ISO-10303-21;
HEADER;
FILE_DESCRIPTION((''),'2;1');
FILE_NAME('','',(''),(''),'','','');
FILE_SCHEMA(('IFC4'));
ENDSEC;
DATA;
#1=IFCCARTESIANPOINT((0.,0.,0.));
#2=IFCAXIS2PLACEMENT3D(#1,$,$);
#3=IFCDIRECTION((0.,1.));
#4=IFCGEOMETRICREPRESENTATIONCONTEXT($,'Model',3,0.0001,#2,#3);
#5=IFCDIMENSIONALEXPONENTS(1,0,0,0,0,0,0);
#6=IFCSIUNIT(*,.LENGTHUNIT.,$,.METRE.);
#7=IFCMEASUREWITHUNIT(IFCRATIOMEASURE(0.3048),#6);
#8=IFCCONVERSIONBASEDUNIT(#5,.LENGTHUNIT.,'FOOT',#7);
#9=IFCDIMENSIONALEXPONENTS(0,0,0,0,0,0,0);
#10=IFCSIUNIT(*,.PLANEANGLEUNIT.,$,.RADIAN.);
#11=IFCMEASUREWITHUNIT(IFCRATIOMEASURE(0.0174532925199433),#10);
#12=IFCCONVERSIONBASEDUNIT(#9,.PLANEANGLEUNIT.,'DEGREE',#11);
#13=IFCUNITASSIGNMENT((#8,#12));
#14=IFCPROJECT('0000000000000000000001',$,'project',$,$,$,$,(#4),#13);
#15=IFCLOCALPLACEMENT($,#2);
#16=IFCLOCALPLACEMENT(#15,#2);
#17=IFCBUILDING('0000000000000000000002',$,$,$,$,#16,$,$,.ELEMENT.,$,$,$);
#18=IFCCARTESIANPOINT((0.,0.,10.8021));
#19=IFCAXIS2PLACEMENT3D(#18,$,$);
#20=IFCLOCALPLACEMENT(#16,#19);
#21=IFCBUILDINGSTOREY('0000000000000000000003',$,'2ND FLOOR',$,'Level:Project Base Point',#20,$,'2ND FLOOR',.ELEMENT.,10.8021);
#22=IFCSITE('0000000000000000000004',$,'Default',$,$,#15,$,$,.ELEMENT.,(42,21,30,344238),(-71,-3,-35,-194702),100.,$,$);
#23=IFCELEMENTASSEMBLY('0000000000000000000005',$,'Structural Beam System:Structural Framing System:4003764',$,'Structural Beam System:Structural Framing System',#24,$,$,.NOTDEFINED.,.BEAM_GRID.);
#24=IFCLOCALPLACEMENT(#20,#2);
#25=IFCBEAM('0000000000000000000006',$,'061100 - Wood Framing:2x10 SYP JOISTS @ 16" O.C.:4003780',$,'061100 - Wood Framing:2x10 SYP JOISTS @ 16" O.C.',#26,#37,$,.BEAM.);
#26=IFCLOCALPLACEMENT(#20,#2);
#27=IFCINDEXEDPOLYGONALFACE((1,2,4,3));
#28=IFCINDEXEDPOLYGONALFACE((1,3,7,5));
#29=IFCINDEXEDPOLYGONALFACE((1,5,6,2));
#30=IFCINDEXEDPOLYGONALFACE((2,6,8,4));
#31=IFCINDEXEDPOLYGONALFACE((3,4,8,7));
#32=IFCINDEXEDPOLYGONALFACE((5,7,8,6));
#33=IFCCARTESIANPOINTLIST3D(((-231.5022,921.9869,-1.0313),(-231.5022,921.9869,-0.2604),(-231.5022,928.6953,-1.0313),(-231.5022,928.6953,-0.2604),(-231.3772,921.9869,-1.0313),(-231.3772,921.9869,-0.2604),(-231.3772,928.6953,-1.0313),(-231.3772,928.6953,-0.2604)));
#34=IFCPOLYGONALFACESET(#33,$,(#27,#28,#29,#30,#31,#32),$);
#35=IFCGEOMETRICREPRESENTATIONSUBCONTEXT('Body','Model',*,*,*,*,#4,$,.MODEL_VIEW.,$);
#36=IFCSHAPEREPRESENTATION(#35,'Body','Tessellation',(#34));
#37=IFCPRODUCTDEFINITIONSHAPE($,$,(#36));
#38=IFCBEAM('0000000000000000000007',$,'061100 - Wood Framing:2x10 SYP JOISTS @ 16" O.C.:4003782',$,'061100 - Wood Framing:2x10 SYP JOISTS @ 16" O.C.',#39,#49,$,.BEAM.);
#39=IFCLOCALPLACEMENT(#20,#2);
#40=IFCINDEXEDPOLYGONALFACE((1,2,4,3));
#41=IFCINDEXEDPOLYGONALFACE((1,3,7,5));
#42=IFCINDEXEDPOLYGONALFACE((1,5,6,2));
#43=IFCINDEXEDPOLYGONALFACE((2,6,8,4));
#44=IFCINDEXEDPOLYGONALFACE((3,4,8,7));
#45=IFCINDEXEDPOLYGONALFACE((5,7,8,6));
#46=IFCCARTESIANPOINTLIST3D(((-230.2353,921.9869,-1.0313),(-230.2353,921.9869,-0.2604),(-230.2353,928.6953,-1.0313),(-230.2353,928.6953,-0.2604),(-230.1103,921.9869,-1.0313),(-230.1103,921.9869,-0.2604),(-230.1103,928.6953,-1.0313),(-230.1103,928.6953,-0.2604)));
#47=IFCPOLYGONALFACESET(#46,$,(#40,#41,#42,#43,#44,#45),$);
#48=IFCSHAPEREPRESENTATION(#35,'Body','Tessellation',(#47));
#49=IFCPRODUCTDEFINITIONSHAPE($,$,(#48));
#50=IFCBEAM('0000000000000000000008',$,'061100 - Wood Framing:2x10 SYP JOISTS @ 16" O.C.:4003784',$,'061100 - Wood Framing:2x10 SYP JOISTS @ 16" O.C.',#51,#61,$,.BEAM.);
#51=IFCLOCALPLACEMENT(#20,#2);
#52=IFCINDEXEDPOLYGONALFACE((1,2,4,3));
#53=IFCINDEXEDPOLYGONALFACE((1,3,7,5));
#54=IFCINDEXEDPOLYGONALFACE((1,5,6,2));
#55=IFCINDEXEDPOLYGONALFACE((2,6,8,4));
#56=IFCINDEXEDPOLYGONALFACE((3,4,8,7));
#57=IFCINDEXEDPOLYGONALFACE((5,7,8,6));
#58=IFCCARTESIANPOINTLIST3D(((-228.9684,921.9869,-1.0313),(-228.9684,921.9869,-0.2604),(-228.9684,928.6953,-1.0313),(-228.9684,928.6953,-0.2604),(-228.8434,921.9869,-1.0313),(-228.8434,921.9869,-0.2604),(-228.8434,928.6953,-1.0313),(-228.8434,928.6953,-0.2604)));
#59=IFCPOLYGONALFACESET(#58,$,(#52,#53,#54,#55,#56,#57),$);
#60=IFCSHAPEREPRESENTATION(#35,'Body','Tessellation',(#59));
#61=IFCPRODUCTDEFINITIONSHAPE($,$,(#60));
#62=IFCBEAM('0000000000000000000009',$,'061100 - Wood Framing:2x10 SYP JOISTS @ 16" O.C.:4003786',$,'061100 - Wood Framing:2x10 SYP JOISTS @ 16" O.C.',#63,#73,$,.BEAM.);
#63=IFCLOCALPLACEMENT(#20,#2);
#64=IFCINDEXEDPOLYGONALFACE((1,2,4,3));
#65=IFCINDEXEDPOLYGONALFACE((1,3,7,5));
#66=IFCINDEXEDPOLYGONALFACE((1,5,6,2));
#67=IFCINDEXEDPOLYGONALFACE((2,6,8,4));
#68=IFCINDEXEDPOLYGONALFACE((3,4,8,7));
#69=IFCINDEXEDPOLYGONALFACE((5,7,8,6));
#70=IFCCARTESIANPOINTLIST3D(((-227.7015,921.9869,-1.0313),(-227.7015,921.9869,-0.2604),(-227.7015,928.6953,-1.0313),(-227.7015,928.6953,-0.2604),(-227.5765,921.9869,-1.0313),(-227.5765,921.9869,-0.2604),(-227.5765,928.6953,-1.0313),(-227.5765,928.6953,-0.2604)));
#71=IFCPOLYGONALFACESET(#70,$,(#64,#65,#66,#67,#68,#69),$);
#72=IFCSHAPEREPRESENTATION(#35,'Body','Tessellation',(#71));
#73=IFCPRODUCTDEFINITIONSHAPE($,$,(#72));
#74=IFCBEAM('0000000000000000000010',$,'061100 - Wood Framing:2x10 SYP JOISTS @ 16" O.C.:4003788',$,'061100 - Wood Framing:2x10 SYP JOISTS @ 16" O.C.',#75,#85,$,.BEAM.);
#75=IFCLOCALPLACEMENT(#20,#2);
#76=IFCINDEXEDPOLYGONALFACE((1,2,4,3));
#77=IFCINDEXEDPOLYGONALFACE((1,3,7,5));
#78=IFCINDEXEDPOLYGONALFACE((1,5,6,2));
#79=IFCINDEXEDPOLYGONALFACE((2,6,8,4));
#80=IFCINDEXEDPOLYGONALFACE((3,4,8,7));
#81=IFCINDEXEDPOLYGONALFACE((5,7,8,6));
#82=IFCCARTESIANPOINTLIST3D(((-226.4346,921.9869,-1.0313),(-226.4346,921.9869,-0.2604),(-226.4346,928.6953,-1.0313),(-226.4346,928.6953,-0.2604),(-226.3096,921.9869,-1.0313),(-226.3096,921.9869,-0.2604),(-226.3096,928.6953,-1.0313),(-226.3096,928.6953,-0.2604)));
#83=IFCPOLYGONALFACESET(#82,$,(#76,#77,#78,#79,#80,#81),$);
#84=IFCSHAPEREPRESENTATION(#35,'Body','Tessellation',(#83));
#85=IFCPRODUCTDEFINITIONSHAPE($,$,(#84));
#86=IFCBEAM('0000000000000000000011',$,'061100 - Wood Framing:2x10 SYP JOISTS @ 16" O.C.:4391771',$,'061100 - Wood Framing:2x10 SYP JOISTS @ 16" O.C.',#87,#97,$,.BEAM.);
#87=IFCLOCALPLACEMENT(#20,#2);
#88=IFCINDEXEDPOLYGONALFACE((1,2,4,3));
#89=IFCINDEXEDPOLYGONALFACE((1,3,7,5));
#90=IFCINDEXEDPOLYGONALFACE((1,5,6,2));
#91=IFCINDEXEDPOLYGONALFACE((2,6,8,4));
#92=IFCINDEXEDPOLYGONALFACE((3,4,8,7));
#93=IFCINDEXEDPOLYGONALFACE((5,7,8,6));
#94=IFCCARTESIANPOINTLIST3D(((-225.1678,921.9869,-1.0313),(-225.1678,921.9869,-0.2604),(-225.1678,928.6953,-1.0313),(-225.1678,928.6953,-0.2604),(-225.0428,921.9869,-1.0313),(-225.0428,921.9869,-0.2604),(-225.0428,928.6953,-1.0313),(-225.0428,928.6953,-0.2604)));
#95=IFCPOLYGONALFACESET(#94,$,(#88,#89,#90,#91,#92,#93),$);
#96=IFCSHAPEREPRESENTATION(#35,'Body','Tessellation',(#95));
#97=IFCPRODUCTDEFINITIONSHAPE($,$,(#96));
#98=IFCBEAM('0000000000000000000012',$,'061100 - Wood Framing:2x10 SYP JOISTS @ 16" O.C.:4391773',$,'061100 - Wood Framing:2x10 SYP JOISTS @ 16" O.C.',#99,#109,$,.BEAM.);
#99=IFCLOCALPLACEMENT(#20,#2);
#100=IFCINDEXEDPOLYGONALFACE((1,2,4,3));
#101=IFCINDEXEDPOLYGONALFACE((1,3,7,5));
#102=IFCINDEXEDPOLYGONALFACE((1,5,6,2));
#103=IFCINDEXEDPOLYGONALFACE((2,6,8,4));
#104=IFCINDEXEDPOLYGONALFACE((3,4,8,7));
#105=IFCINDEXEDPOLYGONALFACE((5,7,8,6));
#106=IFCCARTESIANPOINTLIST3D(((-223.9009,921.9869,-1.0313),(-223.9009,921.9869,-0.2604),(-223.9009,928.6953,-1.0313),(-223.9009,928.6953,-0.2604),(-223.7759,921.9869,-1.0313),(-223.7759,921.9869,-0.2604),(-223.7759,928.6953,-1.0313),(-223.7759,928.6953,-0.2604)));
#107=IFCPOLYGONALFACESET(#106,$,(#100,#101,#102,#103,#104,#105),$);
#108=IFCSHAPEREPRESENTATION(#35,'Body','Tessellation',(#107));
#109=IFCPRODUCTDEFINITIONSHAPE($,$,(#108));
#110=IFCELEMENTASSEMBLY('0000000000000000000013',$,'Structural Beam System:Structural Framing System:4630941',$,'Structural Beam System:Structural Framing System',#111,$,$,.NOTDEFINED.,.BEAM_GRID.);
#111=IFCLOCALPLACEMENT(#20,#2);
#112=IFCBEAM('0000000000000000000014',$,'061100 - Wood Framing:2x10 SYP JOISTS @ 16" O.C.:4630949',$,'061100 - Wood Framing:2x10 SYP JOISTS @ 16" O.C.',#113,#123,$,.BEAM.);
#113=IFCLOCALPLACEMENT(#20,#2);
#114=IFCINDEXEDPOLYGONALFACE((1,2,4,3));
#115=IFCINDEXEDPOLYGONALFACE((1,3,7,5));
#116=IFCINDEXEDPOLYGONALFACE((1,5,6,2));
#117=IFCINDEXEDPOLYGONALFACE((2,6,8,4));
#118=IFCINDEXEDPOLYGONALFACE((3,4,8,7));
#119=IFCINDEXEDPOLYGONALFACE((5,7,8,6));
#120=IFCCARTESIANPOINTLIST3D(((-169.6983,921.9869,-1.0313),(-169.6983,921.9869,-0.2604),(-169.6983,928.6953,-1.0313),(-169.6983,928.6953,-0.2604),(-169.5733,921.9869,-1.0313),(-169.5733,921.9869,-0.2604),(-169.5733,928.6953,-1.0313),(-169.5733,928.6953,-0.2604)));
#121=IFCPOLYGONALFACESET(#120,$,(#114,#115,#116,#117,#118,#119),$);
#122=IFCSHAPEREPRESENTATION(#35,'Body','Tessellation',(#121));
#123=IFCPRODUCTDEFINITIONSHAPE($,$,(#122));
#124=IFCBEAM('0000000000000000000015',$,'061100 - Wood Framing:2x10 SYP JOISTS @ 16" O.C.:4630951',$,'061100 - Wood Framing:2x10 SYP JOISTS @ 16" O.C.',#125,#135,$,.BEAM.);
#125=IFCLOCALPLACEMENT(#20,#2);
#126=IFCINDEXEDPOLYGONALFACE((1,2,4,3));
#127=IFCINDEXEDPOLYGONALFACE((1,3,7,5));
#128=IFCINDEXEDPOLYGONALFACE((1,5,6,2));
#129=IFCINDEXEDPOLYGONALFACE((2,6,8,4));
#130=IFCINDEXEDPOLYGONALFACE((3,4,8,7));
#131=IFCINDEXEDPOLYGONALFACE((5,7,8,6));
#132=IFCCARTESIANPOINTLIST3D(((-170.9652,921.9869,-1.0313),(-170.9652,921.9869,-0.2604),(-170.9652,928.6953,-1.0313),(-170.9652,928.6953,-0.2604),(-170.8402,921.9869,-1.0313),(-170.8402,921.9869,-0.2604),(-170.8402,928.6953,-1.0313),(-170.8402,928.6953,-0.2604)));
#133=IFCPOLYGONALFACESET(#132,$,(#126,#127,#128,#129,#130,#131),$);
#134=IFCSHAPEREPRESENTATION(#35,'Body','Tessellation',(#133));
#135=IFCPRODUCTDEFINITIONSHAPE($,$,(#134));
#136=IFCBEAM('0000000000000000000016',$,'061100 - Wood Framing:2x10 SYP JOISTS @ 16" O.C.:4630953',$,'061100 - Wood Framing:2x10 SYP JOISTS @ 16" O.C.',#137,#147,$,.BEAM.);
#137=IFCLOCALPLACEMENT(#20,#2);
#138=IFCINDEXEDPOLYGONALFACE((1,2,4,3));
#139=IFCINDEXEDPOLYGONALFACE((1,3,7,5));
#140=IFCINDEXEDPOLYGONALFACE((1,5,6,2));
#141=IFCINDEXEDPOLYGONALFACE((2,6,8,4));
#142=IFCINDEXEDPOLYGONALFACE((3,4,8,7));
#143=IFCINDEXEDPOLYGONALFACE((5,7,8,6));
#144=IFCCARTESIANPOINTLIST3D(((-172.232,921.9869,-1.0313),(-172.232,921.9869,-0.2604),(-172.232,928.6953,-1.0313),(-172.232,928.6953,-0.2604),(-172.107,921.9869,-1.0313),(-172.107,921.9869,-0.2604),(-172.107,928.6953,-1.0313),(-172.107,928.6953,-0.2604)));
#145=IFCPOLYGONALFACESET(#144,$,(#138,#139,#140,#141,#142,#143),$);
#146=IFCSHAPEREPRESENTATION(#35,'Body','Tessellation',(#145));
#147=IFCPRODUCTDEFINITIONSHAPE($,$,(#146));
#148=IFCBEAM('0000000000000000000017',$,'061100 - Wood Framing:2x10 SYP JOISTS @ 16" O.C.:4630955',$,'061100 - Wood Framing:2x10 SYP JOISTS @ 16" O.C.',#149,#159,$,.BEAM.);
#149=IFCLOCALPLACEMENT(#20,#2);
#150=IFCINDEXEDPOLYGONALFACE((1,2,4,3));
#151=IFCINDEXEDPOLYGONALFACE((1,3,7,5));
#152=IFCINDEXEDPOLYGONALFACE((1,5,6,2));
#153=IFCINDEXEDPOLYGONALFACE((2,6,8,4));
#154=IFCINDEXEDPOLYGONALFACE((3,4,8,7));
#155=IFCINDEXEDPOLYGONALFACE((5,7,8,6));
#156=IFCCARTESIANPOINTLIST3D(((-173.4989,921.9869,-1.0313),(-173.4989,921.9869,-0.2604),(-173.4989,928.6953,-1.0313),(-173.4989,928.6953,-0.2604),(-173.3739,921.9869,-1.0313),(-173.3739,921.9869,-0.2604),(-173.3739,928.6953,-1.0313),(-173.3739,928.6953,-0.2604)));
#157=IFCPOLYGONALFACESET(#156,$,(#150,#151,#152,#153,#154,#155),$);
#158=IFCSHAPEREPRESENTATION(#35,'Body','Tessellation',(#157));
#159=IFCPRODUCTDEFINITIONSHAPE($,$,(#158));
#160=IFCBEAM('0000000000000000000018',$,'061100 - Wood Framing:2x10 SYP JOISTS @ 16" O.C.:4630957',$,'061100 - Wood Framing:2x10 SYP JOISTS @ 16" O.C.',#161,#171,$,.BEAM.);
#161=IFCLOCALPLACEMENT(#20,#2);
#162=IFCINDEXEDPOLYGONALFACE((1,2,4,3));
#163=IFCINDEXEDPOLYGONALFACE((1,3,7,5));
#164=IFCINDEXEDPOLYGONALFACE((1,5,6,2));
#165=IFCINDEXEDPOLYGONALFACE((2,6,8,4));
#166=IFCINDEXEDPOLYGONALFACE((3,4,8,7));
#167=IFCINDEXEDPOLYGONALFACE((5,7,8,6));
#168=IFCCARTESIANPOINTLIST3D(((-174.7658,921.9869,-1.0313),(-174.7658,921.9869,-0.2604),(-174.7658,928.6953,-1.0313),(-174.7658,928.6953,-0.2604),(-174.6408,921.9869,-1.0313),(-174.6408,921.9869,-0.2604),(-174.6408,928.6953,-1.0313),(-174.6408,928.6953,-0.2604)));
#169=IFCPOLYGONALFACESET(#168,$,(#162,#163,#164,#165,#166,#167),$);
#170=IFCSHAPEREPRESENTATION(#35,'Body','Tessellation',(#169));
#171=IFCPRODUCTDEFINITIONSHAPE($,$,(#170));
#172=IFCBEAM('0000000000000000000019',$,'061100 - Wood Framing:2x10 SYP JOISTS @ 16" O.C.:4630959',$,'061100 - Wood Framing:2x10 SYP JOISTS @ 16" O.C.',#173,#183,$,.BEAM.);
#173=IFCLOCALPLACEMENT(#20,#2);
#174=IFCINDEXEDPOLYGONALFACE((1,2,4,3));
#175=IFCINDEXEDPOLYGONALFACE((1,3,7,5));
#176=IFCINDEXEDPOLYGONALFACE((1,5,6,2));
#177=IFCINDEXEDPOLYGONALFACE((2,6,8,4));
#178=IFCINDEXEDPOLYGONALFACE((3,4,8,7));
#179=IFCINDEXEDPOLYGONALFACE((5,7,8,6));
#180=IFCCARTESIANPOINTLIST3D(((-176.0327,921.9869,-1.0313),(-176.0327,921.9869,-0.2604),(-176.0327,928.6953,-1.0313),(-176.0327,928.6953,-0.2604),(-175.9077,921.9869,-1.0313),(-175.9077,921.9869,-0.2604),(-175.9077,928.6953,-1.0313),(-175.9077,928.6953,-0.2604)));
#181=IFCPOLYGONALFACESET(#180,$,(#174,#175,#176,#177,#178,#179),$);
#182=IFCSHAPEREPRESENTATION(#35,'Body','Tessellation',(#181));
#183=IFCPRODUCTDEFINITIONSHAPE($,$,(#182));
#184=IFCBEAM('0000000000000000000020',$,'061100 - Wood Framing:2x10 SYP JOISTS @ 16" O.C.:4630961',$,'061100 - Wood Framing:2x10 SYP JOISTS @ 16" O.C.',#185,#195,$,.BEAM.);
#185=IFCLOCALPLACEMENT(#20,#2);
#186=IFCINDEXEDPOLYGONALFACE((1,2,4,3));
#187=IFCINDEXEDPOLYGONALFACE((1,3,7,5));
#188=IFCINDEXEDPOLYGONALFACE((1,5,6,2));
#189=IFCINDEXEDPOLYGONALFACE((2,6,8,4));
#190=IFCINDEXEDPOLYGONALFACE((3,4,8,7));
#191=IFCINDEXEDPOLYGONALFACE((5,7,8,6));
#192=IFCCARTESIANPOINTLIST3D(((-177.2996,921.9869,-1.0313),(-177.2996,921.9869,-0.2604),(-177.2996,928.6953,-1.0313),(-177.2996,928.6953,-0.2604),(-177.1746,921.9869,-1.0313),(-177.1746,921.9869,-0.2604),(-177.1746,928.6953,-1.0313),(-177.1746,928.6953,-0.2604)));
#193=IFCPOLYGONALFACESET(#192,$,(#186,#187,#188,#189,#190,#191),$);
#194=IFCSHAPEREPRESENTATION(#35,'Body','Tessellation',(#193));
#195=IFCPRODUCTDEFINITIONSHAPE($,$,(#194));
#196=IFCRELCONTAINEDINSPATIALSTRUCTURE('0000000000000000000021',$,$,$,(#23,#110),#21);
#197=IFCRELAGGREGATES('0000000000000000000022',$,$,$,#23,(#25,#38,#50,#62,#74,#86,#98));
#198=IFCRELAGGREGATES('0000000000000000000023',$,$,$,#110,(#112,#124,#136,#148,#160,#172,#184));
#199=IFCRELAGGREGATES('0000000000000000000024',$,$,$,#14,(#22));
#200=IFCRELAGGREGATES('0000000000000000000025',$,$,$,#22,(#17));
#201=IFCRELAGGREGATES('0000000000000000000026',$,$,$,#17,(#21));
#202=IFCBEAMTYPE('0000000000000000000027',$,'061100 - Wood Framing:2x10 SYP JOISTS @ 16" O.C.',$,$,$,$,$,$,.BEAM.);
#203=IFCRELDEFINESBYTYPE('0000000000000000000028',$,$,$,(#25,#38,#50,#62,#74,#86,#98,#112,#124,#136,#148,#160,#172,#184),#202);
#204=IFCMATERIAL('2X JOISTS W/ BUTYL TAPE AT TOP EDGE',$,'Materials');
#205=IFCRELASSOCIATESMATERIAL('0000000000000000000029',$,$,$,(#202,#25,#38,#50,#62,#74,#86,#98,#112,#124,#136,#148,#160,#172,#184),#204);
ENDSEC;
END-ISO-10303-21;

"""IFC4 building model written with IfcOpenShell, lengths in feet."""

from ifc_helpers import new_model, entity, si_unit, converted_unit, direction, frame, frame_2d, origin, place, context, subcontext, project, spatial, rectangle, extrude, source, transform, mapped, material, material_profile, profile_set, profile_usage, type_object, type_shapes, element, aggregate, save


model = new_model("IFC4")

# Units and contexts
model_context = context("Model", 3, precision=0.0001, world=origin(), true_north=direction((0.0, 1.0)))
body_context = subcontext(model_context, "Body", "Model", "MODEL_VIEW")
ifc_project = project(units=[converted_unit("LENGTHUNIT", "FOOT", entity("IfcRatioMeasure", 0.3048), si_unit("LENGTHUNIT", "METRE"), dimensions=[1, 0, 0, 0, 0, 0, 0]), converted_unit("PLANEANGLEUNIT", "DEGREE", entity("IfcRatioMeasure", 0.0174532925199433), si_unit("PLANEANGLEUNIT", "RADIAN"), dimensions=[0, 0, 0, 0, 0, 0, 0])], contexts=[model_context])

# Site, building, storey
site_placement = place(None, origin())
site = spatial("IfcSite", under=ifc_project, at=site_placement, Name="Default", CompositionType="ELEMENT", RefLatitude=(42, 21, 30, 344238), RefLongitude=(-71, -3, -35, -194702), RefElevation=100.0)
building_placement = place(site_placement, origin())
building = spatial("IfcBuilding", under=site, at=building_placement, CompositionType="ELEMENT")
storey_placement = place(building_placement, frame((0.0, 0.0, 10.8021)))
storey = spatial("IfcBuildingStorey", under=building, at=storey_placement, Name="2ND FLOOR", ObjectType="Level:Project Base Point", LongName="2ND FLOOR", CompositionType="ELEMENT", Elevation=10.8021)

# Element assemblies, beams
assembly_1_placement = place(storey_placement, origin())
assembly_1 = element("IfcElementAssembly", 1, at=assembly_1_placement, inside=storey, Name="Structural Beam System:Structural Framing System:4003764", ObjectType="Structural Beam System:Structural Framing System", AssemblyPlace="NOTDEFINED", PredefinedType="BEAM_GRID")
ifc_material_1 = material(Name="2X JOISTS W/ BUTYL TAPE AT TOP EDGE", Category="Materials")
ifc_material_profile_1 = material_profile(ifc_material_1, rectangle(XDim=0.7708, YDim=0.125, at=frame_2d((0.0, 0.0), x_axis=(1.0, 0.0))), Name="2x10 SYP JOISTS @ 16\" O.C.")
ifc_profile_set_1 = profile_set([ifc_material_profile_1], Name="2x10 SYP JOISTS @ 16\" O.C.")
ifc_profile_usage_1 = profile_usage(ifc_profile_set_1, cardinal=8)
beam_type_1 = type_object("IfcBeamType", Name="061100 - Wood Framing:2x10 SYP JOISTS @ 16\" O.C.", PredefinedType="BEAM", material=ifc_profile_set_1)
shared_shape_1 = source(origin(), body_context, "Body", "SweptSolid", [
    extrude(rectangle(XDim=0.7708, YDim=0.125, at=frame_2d((0.0, 0.0), x_axis=(1.0, 0.0))), frame((-3.3542, 0.0, 0.0), z_axis=(1.0, 0.0, 0.0), x_axis=(0.0, 0.0, -1.0)), (0.0, 0.0, 1.0), 6.7083),
])
type_shapes(beam_type_1, [shared_shape_1])
beam_1_placement = place(assembly_1_placement, frame((-231.4397, 925.3411, -0.6458), z_axis=(0.0, 0.0, 1.0), x_axis=(0.0, 1.0, 0.0)))
beam_1 = element("IfcBeam", 2, at=beam_1_placement, type_object=beam_type_1, material=ifc_profile_usage_1, Name="061100 - Wood Framing:2x10 SYP JOISTS @ 16\" O.C.:4003780", ObjectType="061100 - Wood Framing:2x10 SYP JOISTS @ 16\" O.C.", PredefinedType="BEAM", context=body_context, shape_type="MappedRepresentation", body=[
    mapped(shared_shape_1, transform((0.0, 0.0, 0.0), scale=1.0)),
])
ifc_profile_usage_2 = profile_usage(ifc_profile_set_1, cardinal=8)
beam_2_placement = place(assembly_1_placement, frame((-230.1728, 925.3411, -0.6458), z_axis=(0.0, 0.0, 1.0), x_axis=(0.0, 1.0, 0.0)))
beam_2 = element("IfcBeam", 3, at=beam_2_placement, type_object=beam_type_1, material=ifc_profile_usage_2, Name="061100 - Wood Framing:2x10 SYP JOISTS @ 16\" O.C.:4003782", ObjectType="061100 - Wood Framing:2x10 SYP JOISTS @ 16\" O.C.", PredefinedType="BEAM", context=body_context, shape_type="MappedRepresentation", body=[
    mapped(shared_shape_1, transform((0.0, 0.0, 0.0), scale=1.0)),
])
ifc_profile_usage_3 = profile_usage(ifc_profile_set_1, cardinal=8)
beam_3_placement = place(assembly_1_placement, frame((-228.9059, 925.3411, -0.6458), z_axis=(0.0, 0.0, 1.0), x_axis=(0.0, 1.0, 0.0)))
beam_3 = element("IfcBeam", 4, at=beam_3_placement, type_object=beam_type_1, material=ifc_profile_usage_3, Name="061100 - Wood Framing:2x10 SYP JOISTS @ 16\" O.C.:4003784", ObjectType="061100 - Wood Framing:2x10 SYP JOISTS @ 16\" O.C.", PredefinedType="BEAM", context=body_context, shape_type="MappedRepresentation", body=[
    mapped(shared_shape_1, transform((0.0, 0.0, 0.0), scale=1.0)),
])
ifc_profile_usage_4 = profile_usage(ifc_profile_set_1, cardinal=8)
beam_4_placement = place(assembly_1_placement, frame((-227.639, 925.3411, -0.6458), z_axis=(0.0, 0.0, 1.0), x_axis=(0.0, 1.0, 0.0)))
beam_4 = element("IfcBeam", 5, at=beam_4_placement, type_object=beam_type_1, material=ifc_profile_usage_4, Name="061100 - Wood Framing:2x10 SYP JOISTS @ 16\" O.C.:4003786", ObjectType="061100 - Wood Framing:2x10 SYP JOISTS @ 16\" O.C.", PredefinedType="BEAM", context=body_context, shape_type="MappedRepresentation", body=[
    mapped(shared_shape_1, transform((0.0, 0.0, 0.0), scale=1.0)),
])
ifc_profile_usage_5 = profile_usage(ifc_profile_set_1, cardinal=8)
beam_5_placement = place(assembly_1_placement, frame((-226.3721, 925.3411, -0.6458), z_axis=(0.0, 0.0, 1.0), x_axis=(0.0, 1.0, 0.0)))
beam_5 = element("IfcBeam", 6, at=beam_5_placement, type_object=beam_type_1, material=ifc_profile_usage_5, Name="061100 - Wood Framing:2x10 SYP JOISTS @ 16\" O.C.:4003788", ObjectType="061100 - Wood Framing:2x10 SYP JOISTS @ 16\" O.C.", PredefinedType="BEAM", context=body_context, shape_type="MappedRepresentation", body=[
    mapped(shared_shape_1, transform((0.0, 0.0, 0.0), scale=1.0)),
])
ifc_profile_usage_6 = profile_usage(ifc_profile_set_1, cardinal=8)
beam_6_placement = place(assembly_1_placement, frame((-225.1053, 925.3411, -0.6458), z_axis=(0.0, 0.0, 1.0), x_axis=(0.0, 1.0, 0.0)))
beam_6 = element("IfcBeam", 7, at=beam_6_placement, type_object=beam_type_1, material=ifc_profile_usage_6, Name="061100 - Wood Framing:2x10 SYP JOISTS @ 16\" O.C.:4391771", ObjectType="061100 - Wood Framing:2x10 SYP JOISTS @ 16\" O.C.", PredefinedType="BEAM", context=body_context, shape_type="MappedRepresentation", body=[
    mapped(shared_shape_1, transform((0.0, 0.0, 0.0), scale=1.0)),
])
ifc_profile_usage_7 = profile_usage(ifc_profile_set_1, cardinal=8)
beam_7_placement = place(assembly_1_placement, frame((-223.8384, 925.3411, -0.6458), z_axis=(0.0, 0.0, 1.0), x_axis=(0.0, 1.0, 0.0)))
beam_7 = element("IfcBeam", 8, at=beam_7_placement, type_object=beam_type_1, material=ifc_profile_usage_7, Name="061100 - Wood Framing:2x10 SYP JOISTS @ 16\" O.C.:4391773", ObjectType="061100 - Wood Framing:2x10 SYP JOISTS @ 16\" O.C.", PredefinedType="BEAM", context=body_context, shape_type="MappedRepresentation", body=[
    mapped(shared_shape_1, transform((0.0, 0.0, 0.0), scale=1.0)),
])
aggregate(assembly_1, [beam_1, beam_2, beam_3, beam_4, beam_5, beam_6, beam_7])
assembly_2_placement = place(storey_placement, origin())
assembly_2 = element("IfcElementAssembly", 9, at=assembly_2_placement, inside=storey, Name="Structural Beam System:Structural Framing System:4630941", ObjectType="Structural Beam System:Structural Framing System", AssemblyPlace="NOTDEFINED", PredefinedType="BEAM_GRID")
ifc_profile_usage_8 = profile_usage(ifc_profile_set_1, cardinal=8)
beam_8_placement = place(assembly_2_placement, frame((-169.6358, 925.3411, -0.6458), z_axis=(0.0, 0.0, 1.0), x_axis=(0.0, 1.0, 0.0)))
beam_8 = element("IfcBeam", 10, at=beam_8_placement, type_object=beam_type_1, material=ifc_profile_usage_8, Name="061100 - Wood Framing:2x10 SYP JOISTS @ 16\" O.C.:4630949", ObjectType="061100 - Wood Framing:2x10 SYP JOISTS @ 16\" O.C.", PredefinedType="BEAM", context=body_context, shape_type="MappedRepresentation", body=[
    mapped(shared_shape_1, transform((0.0, 0.0, 0.0), scale=1.0)),
])
ifc_profile_usage_9 = profile_usage(ifc_profile_set_1, cardinal=8)
beam_9_placement = place(assembly_2_placement, frame((-170.9027, 925.3411, -0.6458), z_axis=(0.0, 0.0, 1.0), x_axis=(0.0, 1.0, 0.0)))
beam_9 = element("IfcBeam", 11, at=beam_9_placement, type_object=beam_type_1, material=ifc_profile_usage_9, Name="061100 - Wood Framing:2x10 SYP JOISTS @ 16\" O.C.:4630951", ObjectType="061100 - Wood Framing:2x10 SYP JOISTS @ 16\" O.C.", PredefinedType="BEAM", context=body_context, shape_type="MappedRepresentation", body=[
    mapped(shared_shape_1, transform((0.0, 0.0, 0.0), scale=1.0)),
])
ifc_profile_usage_10 = profile_usage(ifc_profile_set_1, cardinal=8)
beam_10_placement = place(assembly_2_placement, frame((-172.1695, 925.3411, -0.6458), z_axis=(0.0, 0.0, 1.0), x_axis=(0.0, 1.0, 0.0)))
beam_10 = element("IfcBeam", 12, at=beam_10_placement, type_object=beam_type_1, material=ifc_profile_usage_10, Name="061100 - Wood Framing:2x10 SYP JOISTS @ 16\" O.C.:4630953", ObjectType="061100 - Wood Framing:2x10 SYP JOISTS @ 16\" O.C.", PredefinedType="BEAM", context=body_context, shape_type="MappedRepresentation", body=[
    mapped(shared_shape_1, transform((0.0, 0.0, 0.0), scale=1.0)),
])
ifc_profile_usage_11 = profile_usage(ifc_profile_set_1, cardinal=8)
beam_11_placement = place(assembly_2_placement, frame((-173.4364, 925.3411, -0.6458), z_axis=(0.0, 0.0, 1.0), x_axis=(0.0, 1.0, 0.0)))
beam_11 = element("IfcBeam", 13, at=beam_11_placement, type_object=beam_type_1, material=ifc_profile_usage_11, Name="061100 - Wood Framing:2x10 SYP JOISTS @ 16\" O.C.:4630955", ObjectType="061100 - Wood Framing:2x10 SYP JOISTS @ 16\" O.C.", PredefinedType="BEAM", context=body_context, shape_type="MappedRepresentation", body=[
    mapped(shared_shape_1, transform((0.0, 0.0, 0.0), scale=1.0)),
])
ifc_profile_usage_12 = profile_usage(ifc_profile_set_1, cardinal=8)
beam_12_placement = place(assembly_2_placement, frame((-174.7033, 925.3411, -0.6458), z_axis=(0.0, 0.0, 1.0), x_axis=(0.0, 1.0, 0.0)))
beam_12 = element("IfcBeam", 14, at=beam_12_placement, type_object=beam_type_1, material=ifc_profile_usage_12, Name="061100 - Wood Framing:2x10 SYP JOISTS @ 16\" O.C.:4630957", ObjectType="061100 - Wood Framing:2x10 SYP JOISTS @ 16\" O.C.", PredefinedType="BEAM", context=body_context, shape_type="MappedRepresentation", body=[
    mapped(shared_shape_1, transform((0.0, 0.0, 0.0), scale=1.0)),
])
ifc_profile_usage_13 = profile_usage(ifc_profile_set_1, cardinal=8)
beam_13_placement = place(assembly_2_placement, frame((-175.9702, 925.3411, -0.6458), z_axis=(0.0, 0.0, 1.0), x_axis=(0.0, 1.0, 0.0)))
beam_13 = element("IfcBeam", 15, at=beam_13_placement, type_object=beam_type_1, material=ifc_profile_usage_13, Name="061100 - Wood Framing:2x10 SYP JOISTS @ 16\" O.C.:4630959", ObjectType="061100 - Wood Framing:2x10 SYP JOISTS @ 16\" O.C.", PredefinedType="BEAM", context=body_context, shape_type="MappedRepresentation", body=[
    mapped(shared_shape_1, transform((0.0, 0.0, 0.0), scale=1.0)),
])
ifc_profile_usage_14 = profile_usage(ifc_profile_set_1, cardinal=8)
beam_14_placement = place(assembly_2_placement, frame((-177.2371, 925.3411, -0.6458), z_axis=(0.0, 0.0, 1.0), x_axis=(0.0, 1.0, 0.0)))
beam_14 = element("IfcBeam", 16, at=beam_14_placement, type_object=beam_type_1, material=ifc_profile_usage_14, Name="061100 - Wood Framing:2x10 SYP JOISTS @ 16\" O.C.:4630961", ObjectType="061100 - Wood Framing:2x10 SYP JOISTS @ 16\" O.C.", PredefinedType="BEAM", context=body_context, shape_type="MappedRepresentation", body=[
    mapped(shared_shape_1, transform((0.0, 0.0, 0.0), scale=1.0)),
])
aggregate(assembly_2, [beam_8, beam_9, beam_10, beam_11, beam_12, beam_13, beam_14])

save(model, "model.ifc")
